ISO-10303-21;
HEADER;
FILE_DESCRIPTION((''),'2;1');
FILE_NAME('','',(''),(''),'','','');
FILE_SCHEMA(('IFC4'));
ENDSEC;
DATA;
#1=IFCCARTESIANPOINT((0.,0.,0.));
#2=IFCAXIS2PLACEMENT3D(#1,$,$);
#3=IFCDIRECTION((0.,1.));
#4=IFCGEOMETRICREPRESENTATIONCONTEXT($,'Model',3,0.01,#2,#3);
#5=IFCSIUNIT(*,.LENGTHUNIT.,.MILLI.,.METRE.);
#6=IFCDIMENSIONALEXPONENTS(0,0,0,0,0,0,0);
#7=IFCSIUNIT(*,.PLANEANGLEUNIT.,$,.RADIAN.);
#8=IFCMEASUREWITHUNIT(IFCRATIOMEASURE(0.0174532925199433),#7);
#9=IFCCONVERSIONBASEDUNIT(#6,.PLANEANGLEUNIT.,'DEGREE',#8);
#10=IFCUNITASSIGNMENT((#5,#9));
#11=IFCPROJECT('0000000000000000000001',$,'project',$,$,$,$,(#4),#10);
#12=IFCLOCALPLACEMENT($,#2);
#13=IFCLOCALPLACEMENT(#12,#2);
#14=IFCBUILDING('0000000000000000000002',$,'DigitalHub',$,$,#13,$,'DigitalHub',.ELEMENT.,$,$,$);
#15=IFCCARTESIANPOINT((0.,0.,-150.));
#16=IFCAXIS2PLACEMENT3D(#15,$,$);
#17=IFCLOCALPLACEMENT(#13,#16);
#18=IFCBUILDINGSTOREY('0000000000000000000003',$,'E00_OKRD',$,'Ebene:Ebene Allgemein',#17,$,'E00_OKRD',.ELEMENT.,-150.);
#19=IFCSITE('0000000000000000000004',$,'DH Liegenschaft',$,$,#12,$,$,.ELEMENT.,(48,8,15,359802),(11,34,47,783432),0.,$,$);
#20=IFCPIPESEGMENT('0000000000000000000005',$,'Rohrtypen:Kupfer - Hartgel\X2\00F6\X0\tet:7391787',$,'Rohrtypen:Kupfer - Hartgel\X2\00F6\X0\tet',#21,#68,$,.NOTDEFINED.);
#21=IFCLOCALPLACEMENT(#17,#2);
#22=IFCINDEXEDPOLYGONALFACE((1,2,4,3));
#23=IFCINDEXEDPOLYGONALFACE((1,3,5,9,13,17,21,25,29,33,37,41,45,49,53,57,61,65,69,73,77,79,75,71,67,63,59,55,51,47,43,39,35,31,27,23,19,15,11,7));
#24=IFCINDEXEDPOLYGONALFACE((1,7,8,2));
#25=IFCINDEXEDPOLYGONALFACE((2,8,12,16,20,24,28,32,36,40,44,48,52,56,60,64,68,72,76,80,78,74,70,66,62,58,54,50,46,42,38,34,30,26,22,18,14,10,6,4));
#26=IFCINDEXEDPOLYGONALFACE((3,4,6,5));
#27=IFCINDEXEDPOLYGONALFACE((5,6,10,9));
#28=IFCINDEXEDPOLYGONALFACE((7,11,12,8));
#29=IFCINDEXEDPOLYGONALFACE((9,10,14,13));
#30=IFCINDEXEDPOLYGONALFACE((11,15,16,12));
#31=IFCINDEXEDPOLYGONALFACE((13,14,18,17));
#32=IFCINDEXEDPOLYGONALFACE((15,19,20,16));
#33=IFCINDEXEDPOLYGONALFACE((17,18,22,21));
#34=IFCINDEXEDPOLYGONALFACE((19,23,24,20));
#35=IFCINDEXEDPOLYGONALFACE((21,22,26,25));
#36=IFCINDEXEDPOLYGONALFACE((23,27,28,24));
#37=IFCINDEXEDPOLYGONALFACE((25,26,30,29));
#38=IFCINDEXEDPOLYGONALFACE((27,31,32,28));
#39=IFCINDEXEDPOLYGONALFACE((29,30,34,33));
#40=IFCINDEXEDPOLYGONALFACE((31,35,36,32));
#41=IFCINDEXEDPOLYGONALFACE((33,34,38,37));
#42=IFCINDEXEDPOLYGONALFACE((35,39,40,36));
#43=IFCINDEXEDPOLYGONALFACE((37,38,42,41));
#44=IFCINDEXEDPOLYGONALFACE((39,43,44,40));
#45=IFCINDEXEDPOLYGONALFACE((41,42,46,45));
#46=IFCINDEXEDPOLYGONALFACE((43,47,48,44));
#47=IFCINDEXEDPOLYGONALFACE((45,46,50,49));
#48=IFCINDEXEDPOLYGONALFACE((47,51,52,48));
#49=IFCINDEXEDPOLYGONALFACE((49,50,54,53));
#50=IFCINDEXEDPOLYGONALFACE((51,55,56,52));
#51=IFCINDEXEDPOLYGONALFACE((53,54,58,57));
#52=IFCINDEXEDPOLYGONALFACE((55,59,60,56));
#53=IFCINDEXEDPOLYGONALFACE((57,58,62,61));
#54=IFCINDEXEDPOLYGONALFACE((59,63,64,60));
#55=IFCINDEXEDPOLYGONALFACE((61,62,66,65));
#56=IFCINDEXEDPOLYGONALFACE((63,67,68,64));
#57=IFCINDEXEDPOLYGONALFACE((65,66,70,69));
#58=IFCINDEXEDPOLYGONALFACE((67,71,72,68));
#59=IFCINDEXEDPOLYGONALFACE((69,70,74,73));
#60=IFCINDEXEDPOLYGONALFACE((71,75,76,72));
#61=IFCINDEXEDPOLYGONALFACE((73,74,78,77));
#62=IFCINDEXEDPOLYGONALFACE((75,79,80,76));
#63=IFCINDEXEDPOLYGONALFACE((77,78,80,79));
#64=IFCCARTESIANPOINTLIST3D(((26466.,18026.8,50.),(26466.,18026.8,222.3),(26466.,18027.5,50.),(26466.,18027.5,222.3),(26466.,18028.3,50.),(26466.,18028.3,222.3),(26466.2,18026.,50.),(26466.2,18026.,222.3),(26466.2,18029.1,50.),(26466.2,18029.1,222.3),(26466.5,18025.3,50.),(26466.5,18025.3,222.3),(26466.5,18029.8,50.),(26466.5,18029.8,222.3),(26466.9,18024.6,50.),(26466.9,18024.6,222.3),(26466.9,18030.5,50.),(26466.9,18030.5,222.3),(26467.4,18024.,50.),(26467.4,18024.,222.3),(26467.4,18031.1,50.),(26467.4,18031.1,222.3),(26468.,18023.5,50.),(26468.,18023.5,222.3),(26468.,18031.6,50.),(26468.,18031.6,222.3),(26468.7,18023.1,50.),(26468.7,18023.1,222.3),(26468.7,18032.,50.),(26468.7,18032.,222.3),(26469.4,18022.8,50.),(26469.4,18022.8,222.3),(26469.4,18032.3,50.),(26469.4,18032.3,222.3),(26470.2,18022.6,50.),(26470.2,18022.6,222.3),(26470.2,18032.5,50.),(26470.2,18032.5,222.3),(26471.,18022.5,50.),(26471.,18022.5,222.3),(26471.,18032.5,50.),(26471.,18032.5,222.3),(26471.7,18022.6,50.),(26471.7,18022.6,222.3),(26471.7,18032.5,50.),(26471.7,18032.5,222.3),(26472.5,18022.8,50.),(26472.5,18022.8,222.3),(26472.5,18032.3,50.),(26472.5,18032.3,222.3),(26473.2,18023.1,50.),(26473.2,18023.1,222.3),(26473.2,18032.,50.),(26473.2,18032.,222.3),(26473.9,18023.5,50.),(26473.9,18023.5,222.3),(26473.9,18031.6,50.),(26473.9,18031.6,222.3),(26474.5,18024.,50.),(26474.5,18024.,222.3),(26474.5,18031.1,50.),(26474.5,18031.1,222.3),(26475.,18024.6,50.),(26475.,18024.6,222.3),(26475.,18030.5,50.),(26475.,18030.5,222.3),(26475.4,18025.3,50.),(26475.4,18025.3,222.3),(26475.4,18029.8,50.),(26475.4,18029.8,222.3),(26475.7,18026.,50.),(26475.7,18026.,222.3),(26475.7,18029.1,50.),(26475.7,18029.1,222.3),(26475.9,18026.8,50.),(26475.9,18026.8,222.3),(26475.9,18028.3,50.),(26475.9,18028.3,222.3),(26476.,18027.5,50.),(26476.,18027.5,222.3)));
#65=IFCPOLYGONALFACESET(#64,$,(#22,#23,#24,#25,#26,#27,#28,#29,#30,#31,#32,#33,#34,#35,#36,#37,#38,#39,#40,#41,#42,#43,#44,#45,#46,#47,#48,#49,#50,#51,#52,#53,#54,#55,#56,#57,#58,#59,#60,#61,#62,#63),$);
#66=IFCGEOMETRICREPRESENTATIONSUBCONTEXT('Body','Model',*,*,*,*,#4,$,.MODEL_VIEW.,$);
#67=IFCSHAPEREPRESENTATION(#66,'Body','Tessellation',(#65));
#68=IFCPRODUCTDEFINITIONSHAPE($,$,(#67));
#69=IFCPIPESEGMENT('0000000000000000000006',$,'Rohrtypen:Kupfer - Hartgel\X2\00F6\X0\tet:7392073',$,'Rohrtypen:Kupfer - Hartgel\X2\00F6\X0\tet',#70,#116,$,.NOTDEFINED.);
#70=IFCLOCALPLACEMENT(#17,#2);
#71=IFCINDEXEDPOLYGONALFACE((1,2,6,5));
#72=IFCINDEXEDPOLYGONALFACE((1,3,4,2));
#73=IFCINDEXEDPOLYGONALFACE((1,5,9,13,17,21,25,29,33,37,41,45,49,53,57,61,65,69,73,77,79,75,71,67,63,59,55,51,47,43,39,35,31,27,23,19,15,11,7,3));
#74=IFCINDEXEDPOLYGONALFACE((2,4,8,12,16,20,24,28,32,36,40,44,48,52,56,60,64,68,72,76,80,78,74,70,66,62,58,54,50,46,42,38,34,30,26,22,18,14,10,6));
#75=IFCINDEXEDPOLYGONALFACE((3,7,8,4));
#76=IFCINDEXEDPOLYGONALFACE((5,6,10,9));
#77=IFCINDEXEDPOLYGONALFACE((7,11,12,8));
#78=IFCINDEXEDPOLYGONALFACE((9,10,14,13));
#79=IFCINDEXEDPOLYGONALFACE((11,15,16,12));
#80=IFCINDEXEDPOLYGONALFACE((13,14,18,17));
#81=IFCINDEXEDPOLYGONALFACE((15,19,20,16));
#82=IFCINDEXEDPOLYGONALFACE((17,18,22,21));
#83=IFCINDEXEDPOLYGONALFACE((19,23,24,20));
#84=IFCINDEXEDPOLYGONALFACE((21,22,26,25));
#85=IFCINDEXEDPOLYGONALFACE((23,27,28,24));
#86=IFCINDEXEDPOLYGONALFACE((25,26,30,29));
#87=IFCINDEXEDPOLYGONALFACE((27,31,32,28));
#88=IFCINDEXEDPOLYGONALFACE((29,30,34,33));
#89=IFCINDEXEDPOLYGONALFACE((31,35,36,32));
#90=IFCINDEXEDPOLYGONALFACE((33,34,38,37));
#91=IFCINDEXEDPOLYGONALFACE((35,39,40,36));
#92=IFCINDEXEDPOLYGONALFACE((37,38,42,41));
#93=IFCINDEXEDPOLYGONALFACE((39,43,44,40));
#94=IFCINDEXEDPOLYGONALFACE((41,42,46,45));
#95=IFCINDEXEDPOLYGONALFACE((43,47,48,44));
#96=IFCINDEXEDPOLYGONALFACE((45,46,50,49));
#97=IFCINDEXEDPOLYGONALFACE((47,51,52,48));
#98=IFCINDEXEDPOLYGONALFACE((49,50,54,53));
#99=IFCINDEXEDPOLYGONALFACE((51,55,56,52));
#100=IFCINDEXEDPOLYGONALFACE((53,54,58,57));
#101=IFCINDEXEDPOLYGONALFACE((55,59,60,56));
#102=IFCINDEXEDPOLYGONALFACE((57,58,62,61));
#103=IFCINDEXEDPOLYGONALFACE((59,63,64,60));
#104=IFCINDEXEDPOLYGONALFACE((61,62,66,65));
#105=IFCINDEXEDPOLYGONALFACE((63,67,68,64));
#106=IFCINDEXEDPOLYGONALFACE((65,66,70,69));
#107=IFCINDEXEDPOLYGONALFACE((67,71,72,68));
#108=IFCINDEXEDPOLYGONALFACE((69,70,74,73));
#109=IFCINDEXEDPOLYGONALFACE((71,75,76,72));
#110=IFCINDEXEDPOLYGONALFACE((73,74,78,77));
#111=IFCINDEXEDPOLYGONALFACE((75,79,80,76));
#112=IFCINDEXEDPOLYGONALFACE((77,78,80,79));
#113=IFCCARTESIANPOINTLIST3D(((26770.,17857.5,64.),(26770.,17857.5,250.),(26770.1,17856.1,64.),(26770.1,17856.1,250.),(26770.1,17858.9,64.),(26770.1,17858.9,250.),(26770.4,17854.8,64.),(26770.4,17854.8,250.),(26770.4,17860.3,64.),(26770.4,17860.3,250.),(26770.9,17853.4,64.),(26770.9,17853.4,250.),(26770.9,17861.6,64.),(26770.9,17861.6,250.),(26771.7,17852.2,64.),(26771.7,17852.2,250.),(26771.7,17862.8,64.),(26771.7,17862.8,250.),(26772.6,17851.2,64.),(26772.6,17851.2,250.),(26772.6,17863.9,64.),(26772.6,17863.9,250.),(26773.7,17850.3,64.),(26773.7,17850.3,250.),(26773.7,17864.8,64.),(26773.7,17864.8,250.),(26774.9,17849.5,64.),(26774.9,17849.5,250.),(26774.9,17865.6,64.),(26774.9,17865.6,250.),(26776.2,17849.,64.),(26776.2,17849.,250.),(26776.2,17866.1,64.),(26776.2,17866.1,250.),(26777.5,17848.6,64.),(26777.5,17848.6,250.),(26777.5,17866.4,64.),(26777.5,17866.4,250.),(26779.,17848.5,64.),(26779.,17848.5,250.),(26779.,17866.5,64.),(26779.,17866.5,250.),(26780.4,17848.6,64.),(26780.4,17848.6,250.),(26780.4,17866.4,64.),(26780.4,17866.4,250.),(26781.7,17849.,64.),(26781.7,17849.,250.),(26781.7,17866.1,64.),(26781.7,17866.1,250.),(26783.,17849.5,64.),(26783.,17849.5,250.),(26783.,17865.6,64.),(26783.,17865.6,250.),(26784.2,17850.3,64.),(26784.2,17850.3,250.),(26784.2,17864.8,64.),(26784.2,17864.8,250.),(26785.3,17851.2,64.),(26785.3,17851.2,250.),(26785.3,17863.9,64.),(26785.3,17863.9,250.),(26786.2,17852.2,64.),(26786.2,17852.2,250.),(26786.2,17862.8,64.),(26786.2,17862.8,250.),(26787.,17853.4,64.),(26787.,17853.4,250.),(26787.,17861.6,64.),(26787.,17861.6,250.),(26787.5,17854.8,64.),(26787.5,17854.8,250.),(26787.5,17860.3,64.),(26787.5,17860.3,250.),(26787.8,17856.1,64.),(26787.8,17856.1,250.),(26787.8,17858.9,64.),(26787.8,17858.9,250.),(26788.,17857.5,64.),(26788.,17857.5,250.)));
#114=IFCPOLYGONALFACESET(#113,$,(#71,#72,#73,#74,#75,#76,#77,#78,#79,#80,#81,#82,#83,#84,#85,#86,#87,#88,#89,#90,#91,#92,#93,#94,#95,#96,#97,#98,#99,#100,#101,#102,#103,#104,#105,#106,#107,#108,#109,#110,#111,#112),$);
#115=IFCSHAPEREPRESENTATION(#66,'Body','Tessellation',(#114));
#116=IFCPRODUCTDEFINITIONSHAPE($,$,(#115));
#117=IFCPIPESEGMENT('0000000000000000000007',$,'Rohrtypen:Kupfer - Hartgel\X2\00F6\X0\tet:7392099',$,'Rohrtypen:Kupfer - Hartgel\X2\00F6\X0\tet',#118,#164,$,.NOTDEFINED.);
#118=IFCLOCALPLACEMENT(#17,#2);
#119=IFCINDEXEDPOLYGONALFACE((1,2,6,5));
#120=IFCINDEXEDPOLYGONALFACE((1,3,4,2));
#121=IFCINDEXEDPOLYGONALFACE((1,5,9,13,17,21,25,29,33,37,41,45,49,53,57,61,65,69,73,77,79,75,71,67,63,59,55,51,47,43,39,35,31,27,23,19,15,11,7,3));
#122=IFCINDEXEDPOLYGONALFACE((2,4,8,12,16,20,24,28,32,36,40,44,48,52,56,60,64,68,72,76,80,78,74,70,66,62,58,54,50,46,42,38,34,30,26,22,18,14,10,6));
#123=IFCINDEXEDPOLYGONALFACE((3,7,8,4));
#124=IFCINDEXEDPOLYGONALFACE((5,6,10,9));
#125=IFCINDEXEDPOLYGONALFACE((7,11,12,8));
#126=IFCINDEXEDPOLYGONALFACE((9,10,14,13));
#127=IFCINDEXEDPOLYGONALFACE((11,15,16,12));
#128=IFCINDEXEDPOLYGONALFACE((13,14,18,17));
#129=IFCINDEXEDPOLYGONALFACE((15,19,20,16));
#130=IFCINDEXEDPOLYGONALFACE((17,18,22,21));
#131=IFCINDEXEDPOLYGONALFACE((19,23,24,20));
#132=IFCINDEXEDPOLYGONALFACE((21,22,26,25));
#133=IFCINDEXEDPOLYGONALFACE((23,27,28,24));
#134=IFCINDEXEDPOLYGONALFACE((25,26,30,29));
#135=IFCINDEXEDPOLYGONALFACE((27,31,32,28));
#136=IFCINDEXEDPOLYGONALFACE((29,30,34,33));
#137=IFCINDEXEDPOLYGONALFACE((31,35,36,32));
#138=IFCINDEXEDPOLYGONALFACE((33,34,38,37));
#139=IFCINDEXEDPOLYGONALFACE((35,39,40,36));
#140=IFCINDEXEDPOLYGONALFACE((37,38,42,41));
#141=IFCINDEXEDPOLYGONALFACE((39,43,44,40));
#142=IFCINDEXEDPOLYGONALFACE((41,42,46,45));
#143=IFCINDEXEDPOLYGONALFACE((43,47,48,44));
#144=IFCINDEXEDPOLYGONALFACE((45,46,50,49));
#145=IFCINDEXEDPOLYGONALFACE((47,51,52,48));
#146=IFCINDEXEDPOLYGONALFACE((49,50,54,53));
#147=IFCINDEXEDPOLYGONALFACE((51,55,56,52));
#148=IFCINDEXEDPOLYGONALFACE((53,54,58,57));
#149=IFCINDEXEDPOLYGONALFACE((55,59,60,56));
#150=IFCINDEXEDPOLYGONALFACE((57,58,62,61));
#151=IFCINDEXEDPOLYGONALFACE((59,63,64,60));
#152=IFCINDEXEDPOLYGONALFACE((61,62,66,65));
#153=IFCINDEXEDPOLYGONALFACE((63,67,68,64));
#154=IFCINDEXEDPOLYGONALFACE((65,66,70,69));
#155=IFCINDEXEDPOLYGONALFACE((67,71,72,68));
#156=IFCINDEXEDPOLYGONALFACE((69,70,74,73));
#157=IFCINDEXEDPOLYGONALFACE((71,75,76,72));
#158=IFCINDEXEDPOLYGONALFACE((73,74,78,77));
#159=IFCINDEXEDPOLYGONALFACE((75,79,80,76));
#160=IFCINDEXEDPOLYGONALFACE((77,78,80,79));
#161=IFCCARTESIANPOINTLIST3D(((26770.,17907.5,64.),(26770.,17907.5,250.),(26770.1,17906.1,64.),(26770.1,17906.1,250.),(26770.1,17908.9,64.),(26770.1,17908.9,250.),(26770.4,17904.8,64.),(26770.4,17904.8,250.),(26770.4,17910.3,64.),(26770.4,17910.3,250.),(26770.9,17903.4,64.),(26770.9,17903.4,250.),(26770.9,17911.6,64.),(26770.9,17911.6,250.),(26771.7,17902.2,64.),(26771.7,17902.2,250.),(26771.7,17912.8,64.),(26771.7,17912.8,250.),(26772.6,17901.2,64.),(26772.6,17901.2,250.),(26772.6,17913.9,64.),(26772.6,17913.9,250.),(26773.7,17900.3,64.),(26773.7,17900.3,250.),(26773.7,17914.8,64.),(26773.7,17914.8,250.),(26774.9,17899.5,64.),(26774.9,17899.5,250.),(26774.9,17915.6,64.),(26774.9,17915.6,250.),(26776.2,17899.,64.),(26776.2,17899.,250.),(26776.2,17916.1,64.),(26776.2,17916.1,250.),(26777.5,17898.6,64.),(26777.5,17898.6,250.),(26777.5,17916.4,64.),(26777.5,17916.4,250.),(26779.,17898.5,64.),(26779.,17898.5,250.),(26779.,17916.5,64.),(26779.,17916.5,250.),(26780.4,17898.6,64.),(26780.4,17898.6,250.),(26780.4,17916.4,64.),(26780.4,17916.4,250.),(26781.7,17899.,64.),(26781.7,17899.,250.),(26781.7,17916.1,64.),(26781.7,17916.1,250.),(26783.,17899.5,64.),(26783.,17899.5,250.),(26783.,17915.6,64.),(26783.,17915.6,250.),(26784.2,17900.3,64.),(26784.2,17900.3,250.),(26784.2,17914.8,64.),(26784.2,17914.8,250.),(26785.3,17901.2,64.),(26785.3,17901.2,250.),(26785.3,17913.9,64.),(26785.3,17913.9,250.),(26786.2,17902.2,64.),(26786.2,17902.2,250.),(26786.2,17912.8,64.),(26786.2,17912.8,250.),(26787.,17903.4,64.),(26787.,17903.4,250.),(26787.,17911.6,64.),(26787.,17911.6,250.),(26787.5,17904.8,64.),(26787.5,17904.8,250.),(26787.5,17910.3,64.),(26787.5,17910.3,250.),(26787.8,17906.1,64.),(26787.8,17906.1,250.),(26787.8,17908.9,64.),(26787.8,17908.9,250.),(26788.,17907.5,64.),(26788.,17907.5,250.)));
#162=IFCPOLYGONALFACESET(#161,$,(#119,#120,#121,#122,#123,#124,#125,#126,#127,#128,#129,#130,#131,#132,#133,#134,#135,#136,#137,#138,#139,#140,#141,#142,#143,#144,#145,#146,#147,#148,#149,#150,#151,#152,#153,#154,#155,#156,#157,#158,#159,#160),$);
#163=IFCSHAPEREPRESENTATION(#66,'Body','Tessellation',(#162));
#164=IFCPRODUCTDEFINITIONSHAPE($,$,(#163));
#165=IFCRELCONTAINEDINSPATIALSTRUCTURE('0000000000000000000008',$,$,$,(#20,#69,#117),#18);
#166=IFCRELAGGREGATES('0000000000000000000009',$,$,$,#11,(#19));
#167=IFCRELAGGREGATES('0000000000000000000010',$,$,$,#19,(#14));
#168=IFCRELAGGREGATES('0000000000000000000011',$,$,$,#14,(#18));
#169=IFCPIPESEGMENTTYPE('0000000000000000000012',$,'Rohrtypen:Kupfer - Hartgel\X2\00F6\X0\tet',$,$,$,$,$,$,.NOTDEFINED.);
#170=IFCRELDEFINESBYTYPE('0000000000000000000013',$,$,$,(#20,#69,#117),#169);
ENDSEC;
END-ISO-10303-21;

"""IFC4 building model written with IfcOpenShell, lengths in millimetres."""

from ifc_helpers import new_model, entity, si_unit, converted_unit, direction, frame, origin, place, context, subcontext, project, spatial, indexed_curve, outline, extrude, type_object, element, save


model = new_model("IFC4")

# Units and contexts
model_context = context("Model", 3, precision=0.01, world=origin(), true_north=direction((0.0, 1.0)))
body_context = subcontext(model_context, "Body", "Model", "MODEL_VIEW")
ifc_project = project(units=[si_unit("LENGTHUNIT", "METRE", prefix="MILLI"), converted_unit("PLANEANGLEUNIT", "DEGREE", entity("IfcRatioMeasure", 0.0174532925199433), si_unit("PLANEANGLEUNIT", "RADIAN"), dimensions=[0, 0, 0, 0, 0, 0, 0])], contexts=[model_context])

# Site, building, storey
site_placement = place(None, origin())
site = spatial("IfcSite", under=ifc_project, at=site_placement, Name="DH Liegenschaft", CompositionType="ELEMENT", RefLatitude=(48, 8, 15, 359802), RefLongitude=(11, 34, 47, 783432), RefElevation=0.0)
building_placement = place(site_placement, origin())
building = spatial("IfcBuilding", under=site, at=building_placement, Name="DigitalHub", LongName="DigitalHub", CompositionType="ELEMENT")
storey_placement = place(building_placement, frame((0.0, 0.0, -150.0)))
storey = spatial("IfcBuildingStorey", under=building, at=storey_placement, Name="E00_OKRD", ObjectType="Ebene:Ebene Allgemein", LongName="E00_OKRD", CompositionType="ELEMENT", Elevation=-150.0)

# Pipe segments
pipe_segment_type = type_object("IfcPipeSegmentType", Name="Rohrtypen:Kupfer - Hartgelötet", PredefinedType="NOTDEFINED")
pipe_segment_1_placement = place(storey_placement, frame((26464.4, 18020.9, 50.0)))
element("IfcPipeSegment", 1, at=pipe_segment_1_placement, inside=storey, type_object=pipe_segment_type, Name="Rohrtypen:Kupfer - Hartgelötet:7391787", ObjectType="Rohrtypen:Kupfer - Hartgelötet", PredefinedType="NOTDEFINED", context=body_context, shape_type="SweptSolid", body=[
    extrude(outline(indexed_curve([(5.0, 0.0), (4.9, 0.8), (4.8, 1.5), (4.5, 2.3), (4.0, 2.9), (3.5, 3.5), (2.9, 4.0), (2.3, 4.5), (1.5, 4.8), (0.8, 4.9), (0.0, 5.0), (-0.8, 4.9), (-1.5, 4.8), (-2.3, 4.5), (-2.9, 4.0), (-3.5, 3.5), (-4.0, 2.9), (-4.5, 2.3), (-4.8, 1.5), (-4.9, 0.8), (-5.0, 0.0), (-4.9, -0.8), (-4.8, -1.5), (-4.5, -2.3), (-4.0, -2.9), (-3.5, -3.5), (-2.9, -4.0), (-2.3, -4.5), (-1.5, -4.8), (-0.8, -4.9), (0.0, -5.0), (0.8, -4.9), (1.5, -4.8), (2.3, -4.5), (2.9, -4.0), (3.5, -3.5), (4.0, -2.9), (4.5, -2.3), (4.8, -1.5), (4.9, -0.8), (5.0, 0.0)], self_intersect=False)), frame((6.6, 6.6, 0.0)), (0.0, 0.0, 1.0), 172.3),
])
pipe_segment_2_placement = place(storey_placement, frame((26768.4, 17846.9, 64.0)))
element("IfcPipeSegment", 2, at=pipe_segment_2_placement, inside=storey, type_object=pipe_segment_type, Name="Rohrtypen:Kupfer - Hartgelötet:7392073", ObjectType="Rohrtypen:Kupfer - Hartgelötet", PredefinedType="NOTDEFINED", context=body_context, shape_type="SweptSolid", body=[
    extrude(outline(indexed_curve([(9.0, 0.0), (8.9, 1.4), (8.6, 2.8), (8.0, 4.1), (7.3, 5.3), (6.4, 6.4), (5.3, 7.3), (4.1, 8.0), (2.8, 8.6), (1.4, 8.9), (0.0, 9.0), (-1.4, 8.9), (-2.8, 8.6), (-4.1, 8.0), (-5.3, 7.3), (-6.4, 6.4), (-7.3, 5.3), (-8.0, 4.1), (-8.6, 2.8), (-8.9, 1.4), (-9.0, 0.0), (-8.9, -1.4), (-8.6, -2.8), (-8.0, -4.1), (-7.3, -5.3), (-6.4, -6.4), (-5.3, -7.3), (-4.1, -8.0), (-2.8, -8.6), (-1.4, -8.9), (0.0, -9.0), (1.4, -8.9), (2.8, -8.6), (4.1, -8.0), (5.3, -7.3), (6.4, -6.4), (7.3, -5.3), (8.0, -4.1), (8.6, -2.8), (8.9, -1.4), (9.0, 0.0)], self_intersect=False)), frame((10.6, 10.6, 0.0)), (0.0, 0.0, 1.0), 186.0),
])
pipe_segment_3_placement = place(storey_placement, frame((26768.4, 17896.9, 64.0)))
element("IfcPipeSegment", 3, at=pipe_segment_3_placement, inside=storey, type_object=pipe_segment_type, Name="Rohrtypen:Kupfer - Hartgelötet:7392099", ObjectType="Rohrtypen:Kupfer - Hartgelötet", PredefinedType="NOTDEFINED", context=body_context, shape_type="SweptSolid", body=[
    extrude(outline(indexed_curve([(9.0, 0.0), (8.9, 1.4), (8.6, 2.8), (8.0, 4.1), (7.3, 5.3), (6.4, 6.4), (5.3, 7.3), (4.1, 8.0), (2.8, 8.6), (1.4, 8.9), (0.0, 9.0), (-1.4, 8.9), (-2.8, 8.6), (-4.1, 8.0), (-5.3, 7.3), (-6.4, 6.4), (-7.3, 5.3), (-8.0, 4.1), (-8.6, 2.8), (-8.9, 1.4), (-9.0, 0.0), (-8.9, -1.4), (-8.6, -2.8), (-8.0, -4.1), (-7.3, -5.3), (-6.4, -6.4), (-5.3, -7.3), (-4.1, -8.0), (-2.8, -8.6), (-1.4, -8.9), (0.0, -9.0), (1.4, -8.9), (2.8, -8.6), (4.1, -8.0), (5.3, -7.3), (6.4, -6.4), (7.3, -5.3), (8.0, -4.1), (8.6, -2.8), (8.9, -1.4), (9.0, 0.0)], self_intersect=False)), frame((10.6, 10.6, 0.0)), (0.0, 0.0, 1.0), 186.0),
])

save(model, "model.ifc")
